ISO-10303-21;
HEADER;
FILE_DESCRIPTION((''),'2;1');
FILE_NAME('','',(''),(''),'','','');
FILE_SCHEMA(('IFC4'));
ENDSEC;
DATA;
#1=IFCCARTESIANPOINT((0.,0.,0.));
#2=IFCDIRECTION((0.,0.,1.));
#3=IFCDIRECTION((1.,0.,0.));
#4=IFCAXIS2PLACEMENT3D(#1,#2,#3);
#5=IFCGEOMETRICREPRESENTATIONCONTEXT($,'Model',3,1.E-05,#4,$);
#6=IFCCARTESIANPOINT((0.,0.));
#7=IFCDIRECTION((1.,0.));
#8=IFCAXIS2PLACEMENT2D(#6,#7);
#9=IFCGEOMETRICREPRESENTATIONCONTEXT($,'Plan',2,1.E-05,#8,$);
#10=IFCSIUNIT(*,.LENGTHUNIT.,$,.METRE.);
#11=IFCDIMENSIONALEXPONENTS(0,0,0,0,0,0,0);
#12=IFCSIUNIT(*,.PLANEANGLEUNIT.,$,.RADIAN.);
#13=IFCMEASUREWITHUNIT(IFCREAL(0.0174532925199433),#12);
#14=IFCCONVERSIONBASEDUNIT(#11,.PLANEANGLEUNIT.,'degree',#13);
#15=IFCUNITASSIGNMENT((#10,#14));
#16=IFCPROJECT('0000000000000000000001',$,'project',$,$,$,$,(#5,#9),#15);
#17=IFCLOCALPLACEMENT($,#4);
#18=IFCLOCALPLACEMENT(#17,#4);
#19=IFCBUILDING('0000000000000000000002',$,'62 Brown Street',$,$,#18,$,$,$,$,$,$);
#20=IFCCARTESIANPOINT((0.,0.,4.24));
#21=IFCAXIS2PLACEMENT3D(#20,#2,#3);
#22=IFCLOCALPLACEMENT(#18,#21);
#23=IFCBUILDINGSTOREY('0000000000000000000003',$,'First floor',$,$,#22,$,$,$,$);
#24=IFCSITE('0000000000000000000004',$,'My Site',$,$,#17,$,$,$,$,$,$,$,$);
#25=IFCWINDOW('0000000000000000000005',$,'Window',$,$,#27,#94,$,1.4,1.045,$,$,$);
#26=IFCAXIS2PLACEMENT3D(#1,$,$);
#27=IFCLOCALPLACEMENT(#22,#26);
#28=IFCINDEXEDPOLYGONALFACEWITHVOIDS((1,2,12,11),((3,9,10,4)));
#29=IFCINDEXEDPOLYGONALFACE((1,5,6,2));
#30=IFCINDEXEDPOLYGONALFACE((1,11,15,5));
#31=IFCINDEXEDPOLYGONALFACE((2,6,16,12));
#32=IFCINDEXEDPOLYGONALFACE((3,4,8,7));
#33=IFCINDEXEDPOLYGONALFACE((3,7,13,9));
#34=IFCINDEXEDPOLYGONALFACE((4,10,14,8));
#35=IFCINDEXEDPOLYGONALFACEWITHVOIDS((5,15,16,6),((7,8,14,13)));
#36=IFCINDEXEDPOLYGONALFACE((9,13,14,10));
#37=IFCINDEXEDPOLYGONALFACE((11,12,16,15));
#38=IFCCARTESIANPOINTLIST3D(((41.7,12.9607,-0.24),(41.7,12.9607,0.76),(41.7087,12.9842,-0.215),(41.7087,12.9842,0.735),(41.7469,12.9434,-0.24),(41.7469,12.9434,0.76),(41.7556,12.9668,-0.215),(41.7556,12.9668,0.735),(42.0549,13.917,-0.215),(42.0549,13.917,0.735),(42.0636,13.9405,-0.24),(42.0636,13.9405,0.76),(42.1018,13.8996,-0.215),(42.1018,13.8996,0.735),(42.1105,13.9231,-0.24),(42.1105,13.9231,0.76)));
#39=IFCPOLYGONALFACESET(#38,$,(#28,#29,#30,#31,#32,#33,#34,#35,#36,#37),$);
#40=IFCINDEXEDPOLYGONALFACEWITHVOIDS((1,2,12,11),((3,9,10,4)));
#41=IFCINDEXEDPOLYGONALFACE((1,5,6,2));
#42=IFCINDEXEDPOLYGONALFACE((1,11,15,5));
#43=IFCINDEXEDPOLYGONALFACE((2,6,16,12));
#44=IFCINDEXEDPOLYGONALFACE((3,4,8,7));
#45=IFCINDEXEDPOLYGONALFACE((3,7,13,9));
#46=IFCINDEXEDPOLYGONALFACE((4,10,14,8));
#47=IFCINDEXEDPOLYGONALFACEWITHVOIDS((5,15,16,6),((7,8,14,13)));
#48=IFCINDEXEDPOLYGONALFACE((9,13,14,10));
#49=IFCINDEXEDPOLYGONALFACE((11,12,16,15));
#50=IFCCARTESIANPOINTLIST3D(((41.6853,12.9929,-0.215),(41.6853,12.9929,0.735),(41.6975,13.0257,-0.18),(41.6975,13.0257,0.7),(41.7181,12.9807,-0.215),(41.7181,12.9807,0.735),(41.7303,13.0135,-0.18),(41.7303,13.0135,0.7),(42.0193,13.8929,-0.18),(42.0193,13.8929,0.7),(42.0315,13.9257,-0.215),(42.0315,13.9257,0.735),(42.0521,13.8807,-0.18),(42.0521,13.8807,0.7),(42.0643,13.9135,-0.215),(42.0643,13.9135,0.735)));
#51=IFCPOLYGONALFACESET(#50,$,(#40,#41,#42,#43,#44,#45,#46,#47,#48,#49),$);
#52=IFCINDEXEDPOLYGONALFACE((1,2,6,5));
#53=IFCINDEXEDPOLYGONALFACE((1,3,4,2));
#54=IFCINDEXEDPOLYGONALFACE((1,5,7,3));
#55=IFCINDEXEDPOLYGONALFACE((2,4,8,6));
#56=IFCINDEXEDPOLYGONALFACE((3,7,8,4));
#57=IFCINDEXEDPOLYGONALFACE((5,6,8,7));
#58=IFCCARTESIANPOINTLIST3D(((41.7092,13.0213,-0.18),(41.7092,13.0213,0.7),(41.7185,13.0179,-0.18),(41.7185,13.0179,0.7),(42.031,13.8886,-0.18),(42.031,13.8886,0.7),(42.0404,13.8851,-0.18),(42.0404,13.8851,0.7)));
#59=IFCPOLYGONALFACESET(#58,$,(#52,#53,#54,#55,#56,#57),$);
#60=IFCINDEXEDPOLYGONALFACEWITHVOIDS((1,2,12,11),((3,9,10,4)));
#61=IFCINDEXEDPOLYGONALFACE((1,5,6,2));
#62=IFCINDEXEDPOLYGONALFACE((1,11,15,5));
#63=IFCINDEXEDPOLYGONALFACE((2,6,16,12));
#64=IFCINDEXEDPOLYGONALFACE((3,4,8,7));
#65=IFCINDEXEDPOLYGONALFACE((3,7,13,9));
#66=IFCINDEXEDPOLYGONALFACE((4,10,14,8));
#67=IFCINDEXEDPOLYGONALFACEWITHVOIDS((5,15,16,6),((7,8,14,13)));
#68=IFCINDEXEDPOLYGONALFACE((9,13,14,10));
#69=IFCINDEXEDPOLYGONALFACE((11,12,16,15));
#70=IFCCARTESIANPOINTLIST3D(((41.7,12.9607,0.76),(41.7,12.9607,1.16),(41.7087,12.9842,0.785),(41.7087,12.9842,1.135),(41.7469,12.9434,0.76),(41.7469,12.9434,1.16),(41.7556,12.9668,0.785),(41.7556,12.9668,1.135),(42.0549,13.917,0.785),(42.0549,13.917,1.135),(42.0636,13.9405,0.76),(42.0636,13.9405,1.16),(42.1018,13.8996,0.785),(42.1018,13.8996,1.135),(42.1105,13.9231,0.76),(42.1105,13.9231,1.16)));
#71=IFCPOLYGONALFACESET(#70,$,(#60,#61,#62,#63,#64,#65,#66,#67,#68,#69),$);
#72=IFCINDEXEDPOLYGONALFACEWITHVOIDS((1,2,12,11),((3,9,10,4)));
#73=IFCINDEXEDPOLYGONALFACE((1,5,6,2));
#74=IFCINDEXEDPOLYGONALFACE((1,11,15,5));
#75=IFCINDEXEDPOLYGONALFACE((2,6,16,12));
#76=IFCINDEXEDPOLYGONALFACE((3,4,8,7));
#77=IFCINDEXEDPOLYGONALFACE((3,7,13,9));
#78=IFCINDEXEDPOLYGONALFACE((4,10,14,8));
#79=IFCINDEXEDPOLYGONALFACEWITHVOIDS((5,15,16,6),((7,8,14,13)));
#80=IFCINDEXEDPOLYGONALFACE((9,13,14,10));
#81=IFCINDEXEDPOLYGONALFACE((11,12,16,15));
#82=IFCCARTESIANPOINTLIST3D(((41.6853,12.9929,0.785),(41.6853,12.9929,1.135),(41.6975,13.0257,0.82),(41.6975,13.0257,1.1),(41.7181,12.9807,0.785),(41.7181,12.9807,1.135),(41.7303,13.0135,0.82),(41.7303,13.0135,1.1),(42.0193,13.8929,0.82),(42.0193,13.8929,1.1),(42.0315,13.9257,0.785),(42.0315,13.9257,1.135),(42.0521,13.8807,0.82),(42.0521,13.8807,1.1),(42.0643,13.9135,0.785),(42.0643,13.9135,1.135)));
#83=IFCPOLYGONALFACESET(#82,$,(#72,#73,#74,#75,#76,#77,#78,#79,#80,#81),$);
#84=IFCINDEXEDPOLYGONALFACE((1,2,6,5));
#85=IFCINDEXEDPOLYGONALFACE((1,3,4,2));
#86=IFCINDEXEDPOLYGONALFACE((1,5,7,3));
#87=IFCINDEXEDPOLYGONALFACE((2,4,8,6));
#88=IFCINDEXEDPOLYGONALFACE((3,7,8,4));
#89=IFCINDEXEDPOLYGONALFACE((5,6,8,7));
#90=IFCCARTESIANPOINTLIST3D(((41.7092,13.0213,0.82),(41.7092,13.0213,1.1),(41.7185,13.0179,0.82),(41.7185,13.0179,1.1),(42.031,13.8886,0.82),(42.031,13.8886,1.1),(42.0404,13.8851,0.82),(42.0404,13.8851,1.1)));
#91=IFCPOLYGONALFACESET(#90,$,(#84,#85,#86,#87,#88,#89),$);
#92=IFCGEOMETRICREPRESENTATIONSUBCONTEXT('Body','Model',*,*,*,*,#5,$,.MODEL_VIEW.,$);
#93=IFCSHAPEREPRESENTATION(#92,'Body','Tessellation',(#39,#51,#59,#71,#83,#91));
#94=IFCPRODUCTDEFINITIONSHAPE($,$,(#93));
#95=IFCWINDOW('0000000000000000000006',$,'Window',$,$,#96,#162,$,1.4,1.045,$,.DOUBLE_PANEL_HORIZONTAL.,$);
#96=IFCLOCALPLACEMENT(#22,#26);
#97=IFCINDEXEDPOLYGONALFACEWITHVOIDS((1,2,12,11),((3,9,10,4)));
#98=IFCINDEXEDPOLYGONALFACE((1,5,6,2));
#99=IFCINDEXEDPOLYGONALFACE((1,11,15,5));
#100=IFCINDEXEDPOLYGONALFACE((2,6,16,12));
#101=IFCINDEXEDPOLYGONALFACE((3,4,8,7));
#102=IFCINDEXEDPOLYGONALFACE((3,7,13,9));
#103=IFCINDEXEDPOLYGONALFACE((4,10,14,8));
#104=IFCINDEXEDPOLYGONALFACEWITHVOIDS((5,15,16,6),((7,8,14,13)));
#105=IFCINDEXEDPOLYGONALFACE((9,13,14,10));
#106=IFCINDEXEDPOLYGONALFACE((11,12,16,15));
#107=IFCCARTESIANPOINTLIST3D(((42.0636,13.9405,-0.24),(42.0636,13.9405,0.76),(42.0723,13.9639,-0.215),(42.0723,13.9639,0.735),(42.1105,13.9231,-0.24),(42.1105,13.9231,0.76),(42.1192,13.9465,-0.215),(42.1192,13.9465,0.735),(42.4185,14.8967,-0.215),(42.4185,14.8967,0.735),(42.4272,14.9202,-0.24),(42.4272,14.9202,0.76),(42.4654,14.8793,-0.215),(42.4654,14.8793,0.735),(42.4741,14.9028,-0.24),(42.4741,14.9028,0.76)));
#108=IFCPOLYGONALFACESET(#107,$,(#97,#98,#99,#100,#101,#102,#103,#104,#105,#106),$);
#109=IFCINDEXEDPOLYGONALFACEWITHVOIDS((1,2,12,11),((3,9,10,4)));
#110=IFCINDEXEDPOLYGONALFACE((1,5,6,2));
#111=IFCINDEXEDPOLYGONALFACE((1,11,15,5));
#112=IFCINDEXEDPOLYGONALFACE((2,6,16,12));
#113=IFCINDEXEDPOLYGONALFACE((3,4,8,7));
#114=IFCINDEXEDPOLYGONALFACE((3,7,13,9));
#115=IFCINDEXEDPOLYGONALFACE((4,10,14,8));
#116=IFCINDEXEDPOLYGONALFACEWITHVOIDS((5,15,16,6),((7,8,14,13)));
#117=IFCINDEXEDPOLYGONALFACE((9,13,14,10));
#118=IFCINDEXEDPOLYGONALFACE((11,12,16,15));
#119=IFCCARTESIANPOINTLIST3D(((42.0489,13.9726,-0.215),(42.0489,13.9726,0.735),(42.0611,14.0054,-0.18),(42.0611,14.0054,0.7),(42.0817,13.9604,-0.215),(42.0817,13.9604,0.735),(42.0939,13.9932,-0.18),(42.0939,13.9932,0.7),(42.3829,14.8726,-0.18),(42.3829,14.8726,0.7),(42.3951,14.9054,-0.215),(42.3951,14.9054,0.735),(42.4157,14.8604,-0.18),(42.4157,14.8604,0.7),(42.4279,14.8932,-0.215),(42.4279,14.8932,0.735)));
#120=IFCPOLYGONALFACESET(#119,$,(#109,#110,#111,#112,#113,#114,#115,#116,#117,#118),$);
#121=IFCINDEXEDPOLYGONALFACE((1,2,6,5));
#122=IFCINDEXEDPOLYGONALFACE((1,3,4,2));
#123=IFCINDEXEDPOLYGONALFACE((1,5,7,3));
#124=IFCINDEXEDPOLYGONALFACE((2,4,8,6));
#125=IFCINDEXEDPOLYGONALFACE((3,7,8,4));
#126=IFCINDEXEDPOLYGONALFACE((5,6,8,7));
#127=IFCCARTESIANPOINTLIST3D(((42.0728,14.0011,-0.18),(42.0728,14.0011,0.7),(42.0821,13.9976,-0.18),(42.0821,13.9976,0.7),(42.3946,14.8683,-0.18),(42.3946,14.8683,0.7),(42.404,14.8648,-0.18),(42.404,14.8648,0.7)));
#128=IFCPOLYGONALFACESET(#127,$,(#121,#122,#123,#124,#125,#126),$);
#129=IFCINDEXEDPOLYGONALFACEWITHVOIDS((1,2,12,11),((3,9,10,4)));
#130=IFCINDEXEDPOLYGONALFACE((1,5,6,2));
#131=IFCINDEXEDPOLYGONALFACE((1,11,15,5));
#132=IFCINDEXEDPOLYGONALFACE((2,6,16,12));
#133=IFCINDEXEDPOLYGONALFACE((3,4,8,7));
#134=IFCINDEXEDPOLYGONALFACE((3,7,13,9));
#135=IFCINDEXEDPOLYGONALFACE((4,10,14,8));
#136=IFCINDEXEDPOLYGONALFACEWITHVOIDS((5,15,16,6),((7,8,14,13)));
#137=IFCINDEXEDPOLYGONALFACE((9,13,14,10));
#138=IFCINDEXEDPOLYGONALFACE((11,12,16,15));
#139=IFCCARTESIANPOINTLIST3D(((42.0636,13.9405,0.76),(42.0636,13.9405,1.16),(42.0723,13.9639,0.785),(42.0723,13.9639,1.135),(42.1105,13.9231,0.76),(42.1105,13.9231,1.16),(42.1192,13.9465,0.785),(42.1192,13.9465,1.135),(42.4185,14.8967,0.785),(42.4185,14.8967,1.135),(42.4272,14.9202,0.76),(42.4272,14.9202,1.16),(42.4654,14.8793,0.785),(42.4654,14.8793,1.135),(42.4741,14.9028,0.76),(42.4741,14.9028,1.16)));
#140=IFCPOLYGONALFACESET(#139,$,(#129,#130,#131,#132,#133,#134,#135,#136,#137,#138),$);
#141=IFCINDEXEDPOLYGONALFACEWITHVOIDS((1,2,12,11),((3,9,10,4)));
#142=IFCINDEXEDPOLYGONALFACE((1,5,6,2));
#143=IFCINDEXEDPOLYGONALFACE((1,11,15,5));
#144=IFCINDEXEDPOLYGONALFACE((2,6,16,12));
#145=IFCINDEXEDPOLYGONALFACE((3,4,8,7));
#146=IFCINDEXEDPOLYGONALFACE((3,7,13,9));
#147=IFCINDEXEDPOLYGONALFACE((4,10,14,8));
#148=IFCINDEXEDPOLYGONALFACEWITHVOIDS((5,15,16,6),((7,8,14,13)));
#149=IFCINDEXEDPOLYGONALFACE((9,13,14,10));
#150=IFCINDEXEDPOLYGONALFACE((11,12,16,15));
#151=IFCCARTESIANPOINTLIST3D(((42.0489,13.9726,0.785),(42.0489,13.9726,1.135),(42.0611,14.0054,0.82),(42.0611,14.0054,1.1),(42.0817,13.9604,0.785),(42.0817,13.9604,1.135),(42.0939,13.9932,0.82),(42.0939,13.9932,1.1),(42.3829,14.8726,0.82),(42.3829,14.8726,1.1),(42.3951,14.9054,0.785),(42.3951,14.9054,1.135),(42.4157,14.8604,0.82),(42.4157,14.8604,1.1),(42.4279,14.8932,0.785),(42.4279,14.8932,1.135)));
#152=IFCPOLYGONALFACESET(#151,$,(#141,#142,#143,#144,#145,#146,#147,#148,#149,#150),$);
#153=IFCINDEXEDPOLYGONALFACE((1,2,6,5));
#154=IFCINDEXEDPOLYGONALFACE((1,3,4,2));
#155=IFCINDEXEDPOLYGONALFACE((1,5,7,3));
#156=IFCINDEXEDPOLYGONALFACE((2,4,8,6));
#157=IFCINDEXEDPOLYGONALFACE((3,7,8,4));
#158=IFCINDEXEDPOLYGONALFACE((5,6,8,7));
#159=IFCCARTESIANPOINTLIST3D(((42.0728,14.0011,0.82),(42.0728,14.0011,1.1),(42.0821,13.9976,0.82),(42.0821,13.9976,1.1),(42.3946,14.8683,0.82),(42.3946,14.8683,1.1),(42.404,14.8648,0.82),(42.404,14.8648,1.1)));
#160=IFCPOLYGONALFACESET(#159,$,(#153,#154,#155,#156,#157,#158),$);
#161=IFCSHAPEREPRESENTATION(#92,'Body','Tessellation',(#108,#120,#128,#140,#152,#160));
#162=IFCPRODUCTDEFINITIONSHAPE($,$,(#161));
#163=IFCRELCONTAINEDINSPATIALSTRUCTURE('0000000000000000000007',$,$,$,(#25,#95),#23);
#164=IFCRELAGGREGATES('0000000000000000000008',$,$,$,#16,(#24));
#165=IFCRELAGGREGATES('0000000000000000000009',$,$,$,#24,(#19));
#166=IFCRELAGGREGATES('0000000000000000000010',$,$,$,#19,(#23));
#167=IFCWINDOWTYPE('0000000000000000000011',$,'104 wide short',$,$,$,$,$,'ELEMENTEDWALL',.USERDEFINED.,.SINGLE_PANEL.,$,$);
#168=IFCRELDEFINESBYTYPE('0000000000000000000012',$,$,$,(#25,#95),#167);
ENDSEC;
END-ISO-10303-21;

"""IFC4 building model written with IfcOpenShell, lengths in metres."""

from ifc_helpers import new_model, entity, si_unit, converted_unit, frame, origin_with_axes, origin_2d_with_axis, place, context, subcontext, project, spatial, line, indexed_curve, outline, extrude, shape, source, transform, mapped, type_object, type_shapes, element, save


model = new_model("IFC4")

# Units and contexts
model_context = context("Model", 3, precision=1e-05, world=origin_with_axes())
plan_context = context("Plan", 2, precision=1e-05, world=origin_2d_with_axis())
body_context_1 = subcontext(model_context, "Body", "Model", "MODEL_VIEW")
body_context_2 = subcontext(plan_context, "Body", "Plan", "PLAN_VIEW")
ifc_project = project(units=[si_unit("LENGTHUNIT", "METRE"), converted_unit("PLANEANGLEUNIT", "degree", entity("IfcReal", 0.0174532925199433), si_unit("PLANEANGLEUNIT", "RADIAN"), dimensions=[0, 0, 0, 0, 0, 0, 0])], contexts=[model_context, plan_context])

# Site, building, storey
site_placement = place(None, origin_with_axes())
site = spatial("IfcSite", under=ifc_project, at=site_placement, Name="My Site")
building_placement = place(site_placement, origin_with_axes())
building = spatial("IfcBuilding", under=site, at=building_placement, Name="62 Brown Street")
storey_placement = place(building_placement, frame((0.0, 0.0, 4.24), z_axis=(0.0, 0.0, 1.0), x_axis=(1.0, 0.0, 0.0)))
storey = spatial("IfcBuildingStorey", under=building, at=storey_placement, Name="First floor")

# Shared definitions
window_type = type_object("IfcWindowType", Name="104 wide short", ElementType="ELEMENTEDWALL", PartitioningType="SINGLE_PANEL", PredefinedType="USERDEFINED")
shared_shape_1 = source(origin_with_axes(), body_context_1, "Body", "SweptSolid", [
    extrude(outline(indexed_curve([(0.0, 0.0), (1.045, 0.0), (1.045, 1.0), (0.0, 1.0)], segments=[line(1, 2, 3, 4, 1)]), holes=[indexed_curve([(0.025, 0.025), (1.02, 0.025), (1.02, 0.975), (0.025, 0.975)], segments=[line(1, 2, 3, 4, 1)])]), frame((0.0, 0.15, 0.0), z_axis=(0.0, -1.0, 0.0), x_axis=(1.0, 0.0, 0.0)), (0.0, 0.0, -1.0), 0.05),
    extrude(outline(indexed_curve([(0.0, 0.0), (0.995, 0.0), (0.995, 0.95), (0.0, 0.95)], segments=[line(1, 2, 3, 4, 1)]), holes=[indexed_curve([(0.035, 0.035), (0.96, 0.035), (0.96, 0.915), (0.035, 0.915)], segments=[line(1, 2, 3, 4, 1)])]), frame((0.025, 0.19, 0.025), z_axis=(0.0, -1.0, 0.0), x_axis=(1.0, 0.0, 0.0)), (0.0, 0.0, -1.0), 0.035),
    extrude(outline(indexed_curve([(0.035, 0.035), (0.96, 0.035), (0.96, 0.915), (0.035, 0.915)], segments=[line(1, 2, 3, 4, 1)])), frame((0.025, 0.2025, 0.025), z_axis=(0.0, -1.0, 0.0), x_axis=(1.0, 0.0, 0.0)), (0.0, 0.0, -1.0), 0.01),
    extrude(outline(indexed_curve([(0.0, 0.0), (1.045, 0.0), (1.045, 0.4), (0.0, 0.4)], segments=[line(1, 2, 3, 4, 1)]), holes=[indexed_curve([(0.025, 0.025), (1.02, 0.025), (1.02, 0.375), (0.025, 0.375)], segments=[line(1, 2, 3, 4, 1)])]), frame((0.0, 0.15, 1.0), z_axis=(0.0, -1.0, 0.0), x_axis=(1.0, 0.0, 0.0)), (0.0, 0.0, -1.0), 0.05),
    extrude(outline(indexed_curve([(0.0, 0.0), (0.995, 0.0), (0.995, 0.35), (0.0, 0.35)], segments=[line(1, 2, 3, 4, 1)]), holes=[indexed_curve([(0.035, 0.035), (0.96, 0.035), (0.96, 0.315), (0.035, 0.315)], segments=[line(1, 2, 3, 4, 1)])]), frame((0.025, 0.19, 1.025), z_axis=(0.0, -1.0, 0.0), x_axis=(1.0, 0.0, 0.0)), (0.0, 0.0, -1.0), 0.035),
    extrude(outline(indexed_curve([(0.035, 0.035), (0.96, 0.035), (0.96, 0.315), (0.035, 0.315)], segments=[line(1, 2, 3, 4, 1)])), frame((0.025, 0.2025, 1.025), z_axis=(0.0, -1.0, 0.0), x_axis=(1.0, 0.0, 0.0)), (0.0, 0.0, -1.0), 0.01),
])
shared_shape_2 = source(origin_with_axes(), body_context_2, "Body", "Curve2D", [
    entity("IfcIndexedPolyCurve", entity("IfcCartesianPointList2D", [[0.025, 0.15], [1.02, 0.15]])),
    entity("IfcIndexedPolyCurve", entity("IfcCartesianPointList2D", [[0.0, 0.2], [0.025, 0.2], [0.025, 0.15], [0.0, 0.15]]), [entity("IfcLineIndex", [1, 2, 3, 4, 1])]),
    entity("IfcIndexedPolyCurve", entity("IfcCartesianPointList2D", [[1.045, 0.2], [1.02, 0.2], [1.02, 0.15], [1.045, 0.15]]), [entity("IfcLineIndex", [1, 2, 3, 4, 1])]),
    entity("IfcIndexedPolyCurve", entity("IfcCartesianPointList2D", [[0.025, 0.19], [0.06, 0.19], [0.06, 0.225], [0.025, 0.225]]), [entity("IfcLineIndex", [1, 2, 3, 4, 1])]),
    entity("IfcIndexedPolyCurve", entity("IfcCartesianPointList2D", [[1.02, 0.19], [0.985, 0.19], [0.985, 0.225], [1.02, 0.225]]), [entity("IfcLineIndex", [1, 2, 3, 4, 1])]),
    entity("IfcIndexedPolyCurve", entity("IfcCartesianPointList2D", [[0.06, 0.19], [0.985, 0.19]])),
    entity("IfcIndexedPolyCurve", entity("IfcCartesianPointList2D", [[0.06, 0.225], [0.985, 0.225]])),
    entity("IfcIndexedPolyCurve", entity("IfcCartesianPointList2D", [[0.06, 0.2075], [0.985, 0.2075]])),
])
type_shapes(window_type, [shared_shape_1, shared_shape_2])

# Windows
for number, where, z_axis, x_axis, name in (
    (1, (41.8875, 12.8912, -0.24), (0.0, 0.0, 1.0), (0.347944, 0.937515, 0.0), "Window"),
):
    element("IfcWindow", number, at=place(storey_placement, frame(where, z_axis=z_axis, x_axis=x_axis)), inside=storey, type_object=window_type, Name=name, OverallHeight=1.4, OverallWidth=1.045, shapes=[
        shape(body_context_1, "Body", "MappedRepresentation", [mapped(shared_shape_1, transform((0.0, 0.0, 0.0), x_axis=(1.0, 0.0, 0.0), y_axis=(0.0, 1.0, 0.0), z_axis=(0.0, 0.0, 1.0), scale=1.0))]),
        shape(body_context_2, "Body", "MappedRepresentation", [mapped(shared_shape_2, transform((0.0, 0.0, 0.0), x_axis=(1.0, 0.0, 0.0), y_axis=(0.0, 1.0, 0.0), z_axis=(0.0, 0.0, 1.0), scale=1.0))]),
    ])
window_1_placement = place(storey_placement, frame((42.2511, 13.8709, -0.24), z_axis=(0.0, 0.0, 1.0), x_axis=(0.347944, 0.937515, 0.0)))
element("IfcWindow", 2, at=window_1_placement, inside=storey, type_object=window_type, Name="Window", OverallHeight=1.4, OverallWidth=1.045, PartitioningType="DOUBLE_PANEL_HORIZONTAL", shapes=[
    shape(body_context_1, "Body", "MappedRepresentation", [mapped(shared_shape_1, transform((0.0, 0.0, 0.0), x_axis=(1.0, 0.0, 0.0), y_axis=(0.0, 1.0, 0.0), z_axis=(0.0, 0.0, 1.0), scale=1.0))]),
    shape(body_context_2, "Body", "MappedRepresentation", [mapped(shared_shape_2, transform((0.0, 0.0, 0.0), x_axis=(1.0, 0.0, 0.0), y_axis=(0.0, 1.0, 0.0), z_axis=(0.0, 0.0, 1.0), scale=1.0))]),
])

save(model, "model.ifc")
